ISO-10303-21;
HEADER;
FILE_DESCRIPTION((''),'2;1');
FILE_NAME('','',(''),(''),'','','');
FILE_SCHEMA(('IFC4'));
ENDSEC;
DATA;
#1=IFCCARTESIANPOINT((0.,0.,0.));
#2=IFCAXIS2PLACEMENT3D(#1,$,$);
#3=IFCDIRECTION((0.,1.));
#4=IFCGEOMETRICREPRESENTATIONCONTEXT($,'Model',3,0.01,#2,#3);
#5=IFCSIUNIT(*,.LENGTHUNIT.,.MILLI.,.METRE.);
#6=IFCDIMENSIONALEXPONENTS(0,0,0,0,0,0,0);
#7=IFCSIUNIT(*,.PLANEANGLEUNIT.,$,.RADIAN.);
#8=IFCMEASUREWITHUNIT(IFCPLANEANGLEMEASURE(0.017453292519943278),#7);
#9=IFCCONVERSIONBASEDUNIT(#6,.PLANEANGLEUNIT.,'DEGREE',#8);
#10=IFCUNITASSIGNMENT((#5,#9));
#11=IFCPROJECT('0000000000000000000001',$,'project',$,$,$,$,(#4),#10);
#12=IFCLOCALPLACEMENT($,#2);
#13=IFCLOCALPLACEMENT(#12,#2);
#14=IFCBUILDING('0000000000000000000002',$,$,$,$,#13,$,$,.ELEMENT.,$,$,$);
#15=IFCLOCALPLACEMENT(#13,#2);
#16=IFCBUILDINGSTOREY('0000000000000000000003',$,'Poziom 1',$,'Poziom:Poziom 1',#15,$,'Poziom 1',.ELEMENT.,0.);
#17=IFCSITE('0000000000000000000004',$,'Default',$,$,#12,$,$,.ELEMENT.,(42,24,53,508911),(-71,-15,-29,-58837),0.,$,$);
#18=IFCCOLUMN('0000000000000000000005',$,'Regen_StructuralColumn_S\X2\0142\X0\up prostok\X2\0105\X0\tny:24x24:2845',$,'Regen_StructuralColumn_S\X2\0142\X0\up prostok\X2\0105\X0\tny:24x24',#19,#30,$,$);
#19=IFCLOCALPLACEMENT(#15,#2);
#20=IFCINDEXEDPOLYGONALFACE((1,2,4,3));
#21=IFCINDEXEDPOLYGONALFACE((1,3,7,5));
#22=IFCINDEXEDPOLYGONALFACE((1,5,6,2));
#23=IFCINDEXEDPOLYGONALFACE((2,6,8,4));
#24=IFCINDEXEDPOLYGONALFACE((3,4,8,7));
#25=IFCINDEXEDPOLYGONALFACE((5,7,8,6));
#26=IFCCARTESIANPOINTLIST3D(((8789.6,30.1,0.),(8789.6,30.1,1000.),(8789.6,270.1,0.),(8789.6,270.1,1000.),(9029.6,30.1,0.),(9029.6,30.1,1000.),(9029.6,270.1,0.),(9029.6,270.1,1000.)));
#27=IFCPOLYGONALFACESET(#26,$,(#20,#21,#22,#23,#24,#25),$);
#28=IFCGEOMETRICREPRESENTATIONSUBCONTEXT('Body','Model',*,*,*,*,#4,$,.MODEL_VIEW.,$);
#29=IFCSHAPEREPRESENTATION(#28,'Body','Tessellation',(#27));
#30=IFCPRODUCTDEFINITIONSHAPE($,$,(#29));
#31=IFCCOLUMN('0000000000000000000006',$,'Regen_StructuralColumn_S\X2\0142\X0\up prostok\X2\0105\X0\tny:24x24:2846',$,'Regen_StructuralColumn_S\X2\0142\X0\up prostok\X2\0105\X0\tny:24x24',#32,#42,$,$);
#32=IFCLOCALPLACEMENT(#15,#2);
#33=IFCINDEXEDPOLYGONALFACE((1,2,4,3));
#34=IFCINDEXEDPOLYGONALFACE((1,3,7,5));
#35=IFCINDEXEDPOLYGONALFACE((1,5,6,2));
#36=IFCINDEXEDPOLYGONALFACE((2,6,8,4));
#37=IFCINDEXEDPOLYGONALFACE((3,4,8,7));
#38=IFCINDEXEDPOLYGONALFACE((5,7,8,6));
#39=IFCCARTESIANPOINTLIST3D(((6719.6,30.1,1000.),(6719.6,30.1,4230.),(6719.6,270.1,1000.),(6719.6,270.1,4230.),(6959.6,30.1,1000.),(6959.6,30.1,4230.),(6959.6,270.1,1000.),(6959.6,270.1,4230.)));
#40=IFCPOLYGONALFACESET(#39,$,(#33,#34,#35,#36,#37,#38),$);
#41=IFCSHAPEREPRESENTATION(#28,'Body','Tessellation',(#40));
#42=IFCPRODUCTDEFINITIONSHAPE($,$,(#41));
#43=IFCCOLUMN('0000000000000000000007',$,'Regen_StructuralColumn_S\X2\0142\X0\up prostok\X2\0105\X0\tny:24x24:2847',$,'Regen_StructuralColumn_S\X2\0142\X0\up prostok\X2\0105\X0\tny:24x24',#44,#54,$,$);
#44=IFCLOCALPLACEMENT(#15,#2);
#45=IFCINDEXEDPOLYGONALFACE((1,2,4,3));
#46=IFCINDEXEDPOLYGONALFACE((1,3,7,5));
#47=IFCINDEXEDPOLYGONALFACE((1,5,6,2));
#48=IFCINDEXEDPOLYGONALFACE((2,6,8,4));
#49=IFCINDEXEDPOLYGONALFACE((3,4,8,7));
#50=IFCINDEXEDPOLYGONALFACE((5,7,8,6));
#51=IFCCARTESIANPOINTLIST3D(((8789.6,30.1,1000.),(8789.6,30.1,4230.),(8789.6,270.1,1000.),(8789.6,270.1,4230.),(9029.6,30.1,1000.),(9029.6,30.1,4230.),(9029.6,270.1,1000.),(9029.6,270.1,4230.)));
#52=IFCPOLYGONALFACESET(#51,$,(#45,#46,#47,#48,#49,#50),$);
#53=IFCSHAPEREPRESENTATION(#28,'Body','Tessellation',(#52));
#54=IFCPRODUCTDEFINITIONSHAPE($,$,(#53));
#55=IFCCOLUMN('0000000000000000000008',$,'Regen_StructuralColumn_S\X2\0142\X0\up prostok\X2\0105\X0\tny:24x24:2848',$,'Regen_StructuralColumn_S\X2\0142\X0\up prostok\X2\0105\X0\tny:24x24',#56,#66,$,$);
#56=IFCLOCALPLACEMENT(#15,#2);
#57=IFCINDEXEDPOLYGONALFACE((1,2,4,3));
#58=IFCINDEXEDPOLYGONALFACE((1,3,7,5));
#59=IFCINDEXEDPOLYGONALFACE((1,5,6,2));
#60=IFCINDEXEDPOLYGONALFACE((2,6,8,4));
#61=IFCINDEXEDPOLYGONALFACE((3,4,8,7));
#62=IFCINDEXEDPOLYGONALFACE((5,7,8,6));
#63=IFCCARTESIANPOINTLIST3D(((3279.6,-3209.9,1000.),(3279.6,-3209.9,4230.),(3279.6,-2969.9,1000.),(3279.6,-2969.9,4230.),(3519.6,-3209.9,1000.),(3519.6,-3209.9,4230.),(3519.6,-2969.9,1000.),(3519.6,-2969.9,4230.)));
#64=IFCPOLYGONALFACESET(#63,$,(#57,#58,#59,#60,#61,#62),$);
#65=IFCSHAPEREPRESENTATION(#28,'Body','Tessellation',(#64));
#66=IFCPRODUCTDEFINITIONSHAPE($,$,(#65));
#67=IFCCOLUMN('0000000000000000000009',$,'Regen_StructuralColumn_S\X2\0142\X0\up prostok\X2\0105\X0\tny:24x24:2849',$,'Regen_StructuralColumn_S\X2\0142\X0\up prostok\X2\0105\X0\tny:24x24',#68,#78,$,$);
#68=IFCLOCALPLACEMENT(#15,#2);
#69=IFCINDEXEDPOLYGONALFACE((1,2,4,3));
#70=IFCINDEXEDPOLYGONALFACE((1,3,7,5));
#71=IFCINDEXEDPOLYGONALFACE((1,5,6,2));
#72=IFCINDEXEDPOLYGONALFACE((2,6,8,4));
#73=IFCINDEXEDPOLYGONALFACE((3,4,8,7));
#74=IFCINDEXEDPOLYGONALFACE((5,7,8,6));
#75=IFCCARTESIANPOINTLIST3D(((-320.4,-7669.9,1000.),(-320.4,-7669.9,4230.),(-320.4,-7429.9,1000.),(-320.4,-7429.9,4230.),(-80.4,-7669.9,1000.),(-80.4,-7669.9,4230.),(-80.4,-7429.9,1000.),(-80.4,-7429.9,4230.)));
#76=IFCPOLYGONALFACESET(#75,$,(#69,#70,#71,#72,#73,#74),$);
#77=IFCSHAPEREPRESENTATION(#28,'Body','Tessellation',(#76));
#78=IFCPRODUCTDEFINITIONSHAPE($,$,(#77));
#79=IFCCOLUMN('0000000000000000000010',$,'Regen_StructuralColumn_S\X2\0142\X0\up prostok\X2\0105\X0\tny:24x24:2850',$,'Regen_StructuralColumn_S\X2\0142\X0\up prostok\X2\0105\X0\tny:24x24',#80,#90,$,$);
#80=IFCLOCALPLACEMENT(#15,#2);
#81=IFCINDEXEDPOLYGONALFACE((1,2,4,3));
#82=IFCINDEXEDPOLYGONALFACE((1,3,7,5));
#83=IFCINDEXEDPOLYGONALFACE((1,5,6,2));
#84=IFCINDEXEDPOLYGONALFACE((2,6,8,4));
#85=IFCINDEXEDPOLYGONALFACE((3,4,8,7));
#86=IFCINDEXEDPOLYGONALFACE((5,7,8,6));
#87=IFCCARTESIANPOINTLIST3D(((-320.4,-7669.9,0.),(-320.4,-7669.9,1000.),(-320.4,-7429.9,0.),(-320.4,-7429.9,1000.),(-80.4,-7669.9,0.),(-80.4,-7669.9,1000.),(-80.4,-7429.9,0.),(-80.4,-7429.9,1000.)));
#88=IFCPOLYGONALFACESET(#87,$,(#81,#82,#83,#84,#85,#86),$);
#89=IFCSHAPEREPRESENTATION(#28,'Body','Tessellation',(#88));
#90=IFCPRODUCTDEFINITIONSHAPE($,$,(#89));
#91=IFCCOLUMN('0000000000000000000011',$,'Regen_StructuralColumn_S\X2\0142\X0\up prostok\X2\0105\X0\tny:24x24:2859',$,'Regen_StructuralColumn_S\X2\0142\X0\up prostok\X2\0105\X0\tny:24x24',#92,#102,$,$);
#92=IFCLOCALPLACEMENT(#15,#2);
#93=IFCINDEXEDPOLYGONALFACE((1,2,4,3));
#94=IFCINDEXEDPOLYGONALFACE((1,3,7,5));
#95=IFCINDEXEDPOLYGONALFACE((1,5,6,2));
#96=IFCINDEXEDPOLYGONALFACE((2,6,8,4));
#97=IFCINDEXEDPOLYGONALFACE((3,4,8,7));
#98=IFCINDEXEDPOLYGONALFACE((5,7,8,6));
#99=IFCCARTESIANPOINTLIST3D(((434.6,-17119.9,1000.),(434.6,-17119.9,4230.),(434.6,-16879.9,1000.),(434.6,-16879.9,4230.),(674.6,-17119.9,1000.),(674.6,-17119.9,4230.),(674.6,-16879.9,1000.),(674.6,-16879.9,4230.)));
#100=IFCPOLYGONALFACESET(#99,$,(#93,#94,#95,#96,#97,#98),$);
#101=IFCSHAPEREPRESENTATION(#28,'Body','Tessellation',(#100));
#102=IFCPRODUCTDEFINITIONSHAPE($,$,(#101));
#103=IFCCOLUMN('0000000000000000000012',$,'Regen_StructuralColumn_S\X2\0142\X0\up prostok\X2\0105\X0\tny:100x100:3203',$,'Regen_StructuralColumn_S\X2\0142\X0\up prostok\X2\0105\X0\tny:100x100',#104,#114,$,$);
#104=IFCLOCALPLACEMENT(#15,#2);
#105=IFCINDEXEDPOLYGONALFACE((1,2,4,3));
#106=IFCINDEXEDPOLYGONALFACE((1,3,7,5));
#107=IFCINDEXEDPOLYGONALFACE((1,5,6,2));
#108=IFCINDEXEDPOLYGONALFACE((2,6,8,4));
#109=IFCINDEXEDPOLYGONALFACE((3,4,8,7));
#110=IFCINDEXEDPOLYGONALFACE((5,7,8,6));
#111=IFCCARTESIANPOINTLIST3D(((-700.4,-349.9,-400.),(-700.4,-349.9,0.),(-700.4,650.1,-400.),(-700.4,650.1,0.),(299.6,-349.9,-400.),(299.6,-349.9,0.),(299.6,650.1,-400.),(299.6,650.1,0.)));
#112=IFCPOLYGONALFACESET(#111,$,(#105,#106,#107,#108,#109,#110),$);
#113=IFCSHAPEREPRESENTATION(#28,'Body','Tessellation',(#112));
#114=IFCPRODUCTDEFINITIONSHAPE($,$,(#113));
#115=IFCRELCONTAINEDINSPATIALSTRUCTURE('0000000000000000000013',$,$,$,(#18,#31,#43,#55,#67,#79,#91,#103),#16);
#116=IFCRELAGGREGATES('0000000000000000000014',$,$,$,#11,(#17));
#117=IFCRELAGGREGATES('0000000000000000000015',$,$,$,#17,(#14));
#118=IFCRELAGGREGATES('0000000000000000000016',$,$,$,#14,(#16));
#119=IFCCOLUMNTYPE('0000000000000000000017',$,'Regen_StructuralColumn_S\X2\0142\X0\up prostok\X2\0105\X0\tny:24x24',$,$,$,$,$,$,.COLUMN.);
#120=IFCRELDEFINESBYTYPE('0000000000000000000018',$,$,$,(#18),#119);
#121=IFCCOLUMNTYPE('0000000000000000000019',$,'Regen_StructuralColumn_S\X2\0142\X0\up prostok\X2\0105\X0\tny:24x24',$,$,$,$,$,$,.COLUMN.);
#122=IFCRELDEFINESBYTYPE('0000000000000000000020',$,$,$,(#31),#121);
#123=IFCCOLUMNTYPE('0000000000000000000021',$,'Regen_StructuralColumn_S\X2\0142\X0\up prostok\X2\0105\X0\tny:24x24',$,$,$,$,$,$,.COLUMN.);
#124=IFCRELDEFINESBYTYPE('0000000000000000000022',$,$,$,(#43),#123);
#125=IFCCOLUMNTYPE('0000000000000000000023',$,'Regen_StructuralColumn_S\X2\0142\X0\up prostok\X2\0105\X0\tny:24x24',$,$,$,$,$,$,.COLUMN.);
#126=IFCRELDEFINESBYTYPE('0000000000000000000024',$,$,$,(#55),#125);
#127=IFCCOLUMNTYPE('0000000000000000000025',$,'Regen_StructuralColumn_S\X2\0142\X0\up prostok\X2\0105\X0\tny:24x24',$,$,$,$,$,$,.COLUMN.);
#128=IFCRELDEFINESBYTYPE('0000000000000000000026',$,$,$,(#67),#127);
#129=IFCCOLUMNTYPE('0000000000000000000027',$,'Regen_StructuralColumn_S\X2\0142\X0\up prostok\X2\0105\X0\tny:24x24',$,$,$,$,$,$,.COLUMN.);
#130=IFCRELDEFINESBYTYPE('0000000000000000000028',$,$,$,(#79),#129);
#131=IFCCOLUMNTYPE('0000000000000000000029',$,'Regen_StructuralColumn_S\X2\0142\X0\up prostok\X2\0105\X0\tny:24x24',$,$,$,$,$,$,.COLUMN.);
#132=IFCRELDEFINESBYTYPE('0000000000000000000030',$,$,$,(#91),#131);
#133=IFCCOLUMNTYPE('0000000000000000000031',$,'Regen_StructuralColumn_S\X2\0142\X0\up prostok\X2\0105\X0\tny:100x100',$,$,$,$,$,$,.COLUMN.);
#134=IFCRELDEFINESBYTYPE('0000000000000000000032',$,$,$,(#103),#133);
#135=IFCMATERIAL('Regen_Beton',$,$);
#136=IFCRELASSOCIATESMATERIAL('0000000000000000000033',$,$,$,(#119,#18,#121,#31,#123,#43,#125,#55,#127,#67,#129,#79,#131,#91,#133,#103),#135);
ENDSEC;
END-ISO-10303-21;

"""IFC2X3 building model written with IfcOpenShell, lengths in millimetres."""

from ifc_helpers import new_model, entity, si_unit, converted_unit, direction, frame, frame_2d, origin, origin_2d_with_axis, place, context, subcontext, project, spatial, rectangle, extrude, source, transform, mapped, material, type_object, type_shapes, element, save


model = new_model("IFC2X3")

# Units and contexts
model_context = context("Model", 3, precision=0.01, world=origin(), true_north=direction((0.0, 1.0)))
body_context = subcontext(model_context, "Body", "Model", "MODEL_VIEW")
ifc_project = project(units=[si_unit("LENGTHUNIT", "METRE", prefix="MILLI"), converted_unit("PLANEANGLEUNIT", "DEGREE", entity("IfcPlaneAngleMeasure", 0.017453292519943278), si_unit("PLANEANGLEUNIT", "RADIAN"), dimensions=[0, 0, 0, 0, 0, 0, 0])], contexts=[model_context])

# Site, building, storey
site_placement = place(None, origin())
site = spatial("IfcSite", under=ifc_project, at=site_placement, Name="Default", CompositionType="ELEMENT", RefLatitude=(42, 24, 53, 508911), RefLongitude=(-71, -15, -29, -58837), RefElevation=0.0)
building_placement = place(site_placement, origin())
building = spatial("IfcBuilding", under=site, at=building_placement, CompositionType="ELEMENT")
storey_placement = place(building_placement, origin())
storey = spatial("IfcBuildingStorey", under=building, at=storey_placement, Name="Poziom 1", ObjectType="Poziom:Poziom 1", LongName="Poziom 1", CompositionType="ELEMENT", Elevation=0.0)

# Columns
ifc_material = material(Name="Regen_Beton")
column_type_1 = type_object("IfcColumnType", Name="Regen_StructuralColumn_Słup prostokątny:24x24", PredefinedType="COLUMN", material=ifc_material)
shared_shape_1 = source(origin(), body_context, "Body", "SweptSolid", [
    extrude(rectangle(XDim=240.0, YDim=240.0, at=frame_2d((0.0, 0.0), x_axis=(1.0, 0.0))), frame((8909.6, 150.1, 0.0), z_axis=(0.0, 0.0, 1.0), x_axis=(-1.0, 0.0, 0.0)), (0.0, 0.0, 1.0), 1000.0),
])
type_shapes(column_type_1, [shared_shape_1])
column_1_placement = place(storey_placement, origin())
element("IfcColumn", 1, at=column_1_placement, inside=storey, type_object=column_type_1, material=ifc_material, Name="Regen_StructuralColumn_Słup prostokątny:24x24:2845", ObjectType="Regen_StructuralColumn_Słup prostokątny:24x24", context=body_context, shape_type="MappedRepresentation", body=[
    mapped(shared_shape_1, transform((0.0, 0.0, 0.0), scale=1.0)),
])
column_type_2 = type_object("IfcColumnType", Name="Regen_StructuralColumn_Słup prostokątny:24x24", PredefinedType="COLUMN", material=ifc_material)
shared_shape_2 = source(origin(), body_context, "Body", "SweptSolid", [
    extrude(rectangle(XDim=240.0, YDim=240.0, at=origin_2d_with_axis()), frame((6839.6, 150.1, 1000.0), z_axis=(0.0, 0.0, 1.0), x_axis=(-1.0, 0.0, 0.0)), (0.0, 0.0, 1.0), 3230.0),
])
type_shapes(column_type_2, [shared_shape_2])
column_2_placement = place(storey_placement, origin())
element("IfcColumn", 2, at=column_2_placement, inside=storey, type_object=column_type_2, material=ifc_material, Name="Regen_StructuralColumn_Słup prostokątny:24x24:2846", ObjectType="Regen_StructuralColumn_Słup prostokątny:24x24", context=body_context, shape_type="MappedRepresentation", body=[
    mapped(shared_shape_2, transform((0.0, 0.0, 0.0), scale=1.0)),
])
column_type_3 = type_object("IfcColumnType", Name="Regen_StructuralColumn_Słup prostokątny:24x24", PredefinedType="COLUMN", material=ifc_material)
shared_shape_3 = source(origin(), body_context, "Body", "SweptSolid", [
    extrude(rectangle(XDim=240.0, YDim=240.0, at=frame_2d((0.0, 0.0), x_axis=(1.0, 0.0))), frame((8909.6, 150.1, 1000.0), z_axis=(0.0, 0.0, 1.0), x_axis=(-1.0, 0.0, 0.0)), (0.0, 0.0, 1.0), 3230.0),
])
type_shapes(column_type_3, [shared_shape_3])
column_3_placement = place(storey_placement, origin())
element("IfcColumn", 3, at=column_3_placement, inside=storey, type_object=column_type_3, material=ifc_material, Name="Regen_StructuralColumn_Słup prostokątny:24x24:2847", ObjectType="Regen_StructuralColumn_Słup prostokątny:24x24", context=body_context, shape_type="MappedRepresentation", body=[
    mapped(shared_shape_3, transform((0.0, 0.0, 0.0), scale=1.0)),
])
column_type_4 = type_object("IfcColumnType", Name="Regen_StructuralColumn_Słup prostokątny:24x24", PredefinedType="COLUMN", material=ifc_material)
shared_shape_4 = source(origin(), body_context, "Body", "SweptSolid", [
    extrude(rectangle(XDim=240.0, YDim=240.0, at=frame_2d((0.0, 0.0), x_axis=(1.0, 0.0))), frame((3399.6, -3089.9, 1000.0), z_axis=(0.0, 0.0, 1.0), x_axis=(-1.0, 0.0, 0.0)), (0.0, 0.0, 1.0), 3230.0),
])
type_shapes(column_type_4, [shared_shape_4])
column_4_placement = place(storey_placement, origin())
element("IfcColumn", 4, at=column_4_placement, inside=storey, type_object=column_type_4, material=ifc_material, Name="Regen_StructuralColumn_Słup prostokątny:24x24:2848", ObjectType="Regen_StructuralColumn_Słup prostokątny:24x24", context=body_context, shape_type="MappedRepresentation", body=[
    mapped(shared_shape_4, transform((0.0, 0.0, 0.0), scale=1.0)),
])
column_type_5 = type_object("IfcColumnType", Name="Regen_StructuralColumn_Słup prostokątny:24x24", PredefinedType="COLUMN", material=ifc_material)
shared_shape_5 = source(origin(), body_context, "Body", "SweptSolid", [
    extrude(rectangle(XDim=240.0, YDim=240.0, at=origin_2d_with_axis()), frame((-200.4, -7549.9, 1000.0), z_axis=(0.0, 0.0, 1.0), x_axis=(-1.0, 0.0, 0.0)), (0.0, 0.0, 1.0), 3230.0),
])
type_shapes(column_type_5, [shared_shape_5])
column_5_placement = place(storey_placement, origin())
element("IfcColumn", 5, at=column_5_placement, inside=storey, type_object=column_type_5, material=ifc_material, Name="Regen_StructuralColumn_Słup prostokątny:24x24:2849", ObjectType="Regen_StructuralColumn_Słup prostokątny:24x24", context=body_context, shape_type="MappedRepresentation", body=[
    mapped(shared_shape_5, transform((0.0, 0.0, 0.0), scale=1.0)),
])
column_type_6 = type_object("IfcColumnType", Name="Regen_StructuralColumn_Słup prostokątny:24x24", PredefinedType="COLUMN", material=ifc_material)
shared_shape_6 = source(origin(), body_context, "Body", "SweptSolid", [
    extrude(rectangle(XDim=240.0, YDim=240.0, at=frame_2d((0.0, 0.0), x_axis=(1.0, 0.0))), frame((-200.4, -7549.9, 0.0), z_axis=(0.0, 0.0, 1.0), x_axis=(-1.0, 0.0, 0.0)), (0.0, 0.0, 1.0), 1000.0),
])
type_shapes(column_type_6, [shared_shape_6])
column_6_placement = place(storey_placement, origin())
element("IfcColumn", 6, at=column_6_placement, inside=storey, type_object=column_type_6, material=ifc_material, Name="Regen_StructuralColumn_Słup prostokątny:24x24:2850", ObjectType="Regen_StructuralColumn_Słup prostokątny:24x24", context=body_context, shape_type="MappedRepresentation", body=[
    mapped(shared_shape_6, transform((0.0, 0.0, 0.0), scale=1.0)),
])
column_type_7 = type_object("IfcColumnType", Name="Regen_StructuralColumn_Słup prostokątny:24x24", PredefinedType="COLUMN", material=ifc_material)
shared_shape_7 = source(origin(), body_context, "Body", "SweptSolid", [
    extrude(rectangle(XDim=240.0, YDim=240.0, at=frame_2d((0.0, 0.0), x_axis=(1.0, 0.0))), frame((554.6, -16999.9, 1000.0), z_axis=(0.0, 0.0, 1.0), x_axis=(-1.0, 0.0, 0.0)), (0.0, 0.0, 1.0), 3230.0),
])
type_shapes(column_type_7, [shared_shape_7])
column_7_placement = place(storey_placement, origin())
element("IfcColumn", 7, at=column_7_placement, inside=storey, type_object=column_type_7, material=ifc_material, Name="Regen_StructuralColumn_Słup prostokątny:24x24:2859", ObjectType="Regen_StructuralColumn_Słup prostokątny:24x24", context=body_context, shape_type="MappedRepresentation", body=[
    mapped(shared_shape_7, transform((0.0, 0.0, 0.0), scale=1.0)),
])
column_type_8 = type_object("IfcColumnType", Name="Regen_StructuralColumn_Słup prostokątny:100x100", PredefinedType="COLUMN", material=ifc_material)
shared_shape_8 = source(origin(), body_context, "Body", "SweptSolid", [
    extrude(rectangle(XDim=1000.0, YDim=1000.0, at=origin_2d_with_axis()), frame((0.0, 0.0, -400.0), z_axis=(0.0, 0.0, 1.0), x_axis=(-1.0, 0.0, 0.0)), (0.0, 0.0, 1.0), 400.0),
])
type_shapes(column_type_8, [shared_shape_8])
column_8_placement = place(storey_placement, frame((-200.4, 150.1, 0.0)))
element("IfcColumn", 8, at=column_8_placement, inside=storey, type_object=column_type_8, material=ifc_material, Name="Regen_StructuralColumn_Słup prostokątny:100x100:3203", ObjectType="Regen_StructuralColumn_Słup prostokątny:100x100", context=body_context, shape_type="MappedRepresentation", body=[
    mapped(shared_shape_8, transform((0.0, 0.0, 0.0), scale=1.0)),
])

save(model, "model.ifc")
